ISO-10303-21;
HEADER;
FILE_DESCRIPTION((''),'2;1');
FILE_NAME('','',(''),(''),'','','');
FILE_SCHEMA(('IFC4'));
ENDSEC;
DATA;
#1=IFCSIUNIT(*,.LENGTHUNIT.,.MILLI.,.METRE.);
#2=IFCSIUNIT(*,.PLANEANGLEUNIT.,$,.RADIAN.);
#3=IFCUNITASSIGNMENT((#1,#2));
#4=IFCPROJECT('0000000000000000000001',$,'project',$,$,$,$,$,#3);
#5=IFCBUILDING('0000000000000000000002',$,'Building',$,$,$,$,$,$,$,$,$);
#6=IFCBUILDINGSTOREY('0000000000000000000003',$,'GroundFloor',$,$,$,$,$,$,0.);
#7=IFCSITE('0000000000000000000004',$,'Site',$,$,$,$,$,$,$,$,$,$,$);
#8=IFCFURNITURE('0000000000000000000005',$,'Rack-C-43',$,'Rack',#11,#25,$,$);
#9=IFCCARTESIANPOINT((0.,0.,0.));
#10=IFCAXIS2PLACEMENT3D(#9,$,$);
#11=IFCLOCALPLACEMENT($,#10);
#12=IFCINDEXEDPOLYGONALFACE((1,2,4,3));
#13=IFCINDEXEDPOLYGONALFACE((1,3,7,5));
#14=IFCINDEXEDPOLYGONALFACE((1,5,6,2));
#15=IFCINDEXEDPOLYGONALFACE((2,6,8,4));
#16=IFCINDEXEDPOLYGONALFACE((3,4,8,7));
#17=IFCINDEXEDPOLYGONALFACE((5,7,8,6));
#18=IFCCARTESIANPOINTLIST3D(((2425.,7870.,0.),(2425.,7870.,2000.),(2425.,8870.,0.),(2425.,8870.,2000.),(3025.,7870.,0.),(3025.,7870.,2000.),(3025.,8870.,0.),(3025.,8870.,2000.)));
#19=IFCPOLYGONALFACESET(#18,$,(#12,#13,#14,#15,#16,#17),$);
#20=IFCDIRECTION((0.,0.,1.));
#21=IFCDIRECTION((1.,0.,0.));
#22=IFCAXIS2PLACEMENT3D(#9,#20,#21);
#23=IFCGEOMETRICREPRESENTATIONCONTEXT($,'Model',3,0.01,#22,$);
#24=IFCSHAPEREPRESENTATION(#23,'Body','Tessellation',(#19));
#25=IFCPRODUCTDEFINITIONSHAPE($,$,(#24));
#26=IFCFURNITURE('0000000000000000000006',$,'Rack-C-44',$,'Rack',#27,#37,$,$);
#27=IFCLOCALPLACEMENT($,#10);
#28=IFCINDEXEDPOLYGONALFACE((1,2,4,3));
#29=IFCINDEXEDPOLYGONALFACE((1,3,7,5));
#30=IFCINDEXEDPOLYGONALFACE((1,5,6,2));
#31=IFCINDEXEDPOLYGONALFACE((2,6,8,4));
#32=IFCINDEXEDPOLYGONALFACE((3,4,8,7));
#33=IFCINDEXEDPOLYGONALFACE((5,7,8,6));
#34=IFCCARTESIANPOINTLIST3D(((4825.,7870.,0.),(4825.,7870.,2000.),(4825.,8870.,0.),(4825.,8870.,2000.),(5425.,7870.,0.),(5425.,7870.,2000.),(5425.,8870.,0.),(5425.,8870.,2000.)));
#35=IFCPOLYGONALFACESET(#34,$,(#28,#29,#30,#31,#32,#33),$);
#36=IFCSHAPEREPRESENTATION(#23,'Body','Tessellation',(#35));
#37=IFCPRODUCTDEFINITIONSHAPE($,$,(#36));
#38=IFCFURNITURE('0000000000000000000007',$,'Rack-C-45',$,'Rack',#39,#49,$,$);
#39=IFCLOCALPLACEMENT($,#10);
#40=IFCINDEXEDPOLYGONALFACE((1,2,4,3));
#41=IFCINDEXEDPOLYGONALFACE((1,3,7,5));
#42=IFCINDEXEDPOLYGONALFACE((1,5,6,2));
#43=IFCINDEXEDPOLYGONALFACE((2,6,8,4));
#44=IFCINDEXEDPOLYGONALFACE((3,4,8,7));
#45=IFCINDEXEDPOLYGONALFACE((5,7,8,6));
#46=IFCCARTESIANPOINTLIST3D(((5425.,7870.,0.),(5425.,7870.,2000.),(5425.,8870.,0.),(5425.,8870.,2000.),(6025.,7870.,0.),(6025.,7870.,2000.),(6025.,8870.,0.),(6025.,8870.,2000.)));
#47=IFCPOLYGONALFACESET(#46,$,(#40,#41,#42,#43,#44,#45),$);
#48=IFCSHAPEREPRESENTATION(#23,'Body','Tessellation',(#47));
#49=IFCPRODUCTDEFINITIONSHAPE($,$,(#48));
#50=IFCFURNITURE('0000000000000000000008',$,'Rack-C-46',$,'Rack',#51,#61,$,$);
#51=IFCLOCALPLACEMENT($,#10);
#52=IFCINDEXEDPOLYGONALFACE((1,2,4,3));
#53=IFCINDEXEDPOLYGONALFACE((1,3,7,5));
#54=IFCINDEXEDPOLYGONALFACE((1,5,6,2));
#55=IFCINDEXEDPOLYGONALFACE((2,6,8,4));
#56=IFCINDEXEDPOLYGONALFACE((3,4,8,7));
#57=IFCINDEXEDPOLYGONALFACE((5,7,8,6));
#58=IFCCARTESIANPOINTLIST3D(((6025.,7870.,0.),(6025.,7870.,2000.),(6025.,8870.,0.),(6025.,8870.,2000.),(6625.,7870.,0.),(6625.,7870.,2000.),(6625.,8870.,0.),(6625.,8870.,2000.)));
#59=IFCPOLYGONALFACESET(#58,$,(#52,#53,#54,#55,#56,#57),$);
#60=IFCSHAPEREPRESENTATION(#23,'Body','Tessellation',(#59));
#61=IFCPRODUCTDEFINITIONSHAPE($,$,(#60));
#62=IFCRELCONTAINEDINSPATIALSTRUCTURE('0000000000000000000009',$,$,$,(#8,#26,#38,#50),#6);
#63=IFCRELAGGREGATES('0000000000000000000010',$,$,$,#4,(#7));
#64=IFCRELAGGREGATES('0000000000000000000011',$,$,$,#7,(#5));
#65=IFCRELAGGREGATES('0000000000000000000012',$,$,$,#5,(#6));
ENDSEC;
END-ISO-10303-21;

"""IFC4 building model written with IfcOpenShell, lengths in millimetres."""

from ifc_helpers import new_model, si_unit, frame, origin, origin_with_axes, origin_2d, place, context, project, spatial, rectangle, extrude, element, save


model = new_model("IFC4")

# Units and contexts
model_context = context("Model", 3, precision=0.01, world=origin_with_axes())
ifc_project = project(units=[si_unit("LENGTHUNIT", "METRE", prefix="MILLI"), si_unit("PLANEANGLEUNIT", "RADIAN")])

# Site, building, storey
site = spatial("IfcSite", under=ifc_project, Name="Site")
building = spatial("IfcBuilding", under=site, Name="Building")
storey = spatial("IfcBuildingStorey", under=building, Name="GroundFloor", Elevation=0.0)

# Furniture
for number, where, z_axis, x_axis, name in (
    (1, (2725.0, 8370.0, 0.0), (0.0, 0.0, 1.0), (1.0, 0.0, 0.0), "Rack-C-43"),
    (2, (5125.0, 8370.0, 0.0), (0.0, 0.0, 1.0), (1.0, 0.0, 0.0), "Rack-C-44"),
    (3, (5725.0, 8370.0, 0.0), (0.0, 0.0, 1.0), (1.0, 0.0, 0.0), "Rack-C-45"),
    (4, (6325.0, 8370.0, 0.0), (0.0, 0.0, 1.0), (1.0, 0.0, 0.0), "Rack-C-46"),
):
    element("IfcFurniture", number, at=place(None, frame(where, z_axis=z_axis, x_axis=x_axis)), inside=storey, Name=name, ObjectType="Rack", context=model_context, shape_type="SweptSolid", body=[
        extrude(rectangle(XDim=600.0, YDim=1000.0, at=origin_2d()), origin(), (0.0, 0.0, 1.0), 2000.0),
    ])

save(model, "model.ifc")
